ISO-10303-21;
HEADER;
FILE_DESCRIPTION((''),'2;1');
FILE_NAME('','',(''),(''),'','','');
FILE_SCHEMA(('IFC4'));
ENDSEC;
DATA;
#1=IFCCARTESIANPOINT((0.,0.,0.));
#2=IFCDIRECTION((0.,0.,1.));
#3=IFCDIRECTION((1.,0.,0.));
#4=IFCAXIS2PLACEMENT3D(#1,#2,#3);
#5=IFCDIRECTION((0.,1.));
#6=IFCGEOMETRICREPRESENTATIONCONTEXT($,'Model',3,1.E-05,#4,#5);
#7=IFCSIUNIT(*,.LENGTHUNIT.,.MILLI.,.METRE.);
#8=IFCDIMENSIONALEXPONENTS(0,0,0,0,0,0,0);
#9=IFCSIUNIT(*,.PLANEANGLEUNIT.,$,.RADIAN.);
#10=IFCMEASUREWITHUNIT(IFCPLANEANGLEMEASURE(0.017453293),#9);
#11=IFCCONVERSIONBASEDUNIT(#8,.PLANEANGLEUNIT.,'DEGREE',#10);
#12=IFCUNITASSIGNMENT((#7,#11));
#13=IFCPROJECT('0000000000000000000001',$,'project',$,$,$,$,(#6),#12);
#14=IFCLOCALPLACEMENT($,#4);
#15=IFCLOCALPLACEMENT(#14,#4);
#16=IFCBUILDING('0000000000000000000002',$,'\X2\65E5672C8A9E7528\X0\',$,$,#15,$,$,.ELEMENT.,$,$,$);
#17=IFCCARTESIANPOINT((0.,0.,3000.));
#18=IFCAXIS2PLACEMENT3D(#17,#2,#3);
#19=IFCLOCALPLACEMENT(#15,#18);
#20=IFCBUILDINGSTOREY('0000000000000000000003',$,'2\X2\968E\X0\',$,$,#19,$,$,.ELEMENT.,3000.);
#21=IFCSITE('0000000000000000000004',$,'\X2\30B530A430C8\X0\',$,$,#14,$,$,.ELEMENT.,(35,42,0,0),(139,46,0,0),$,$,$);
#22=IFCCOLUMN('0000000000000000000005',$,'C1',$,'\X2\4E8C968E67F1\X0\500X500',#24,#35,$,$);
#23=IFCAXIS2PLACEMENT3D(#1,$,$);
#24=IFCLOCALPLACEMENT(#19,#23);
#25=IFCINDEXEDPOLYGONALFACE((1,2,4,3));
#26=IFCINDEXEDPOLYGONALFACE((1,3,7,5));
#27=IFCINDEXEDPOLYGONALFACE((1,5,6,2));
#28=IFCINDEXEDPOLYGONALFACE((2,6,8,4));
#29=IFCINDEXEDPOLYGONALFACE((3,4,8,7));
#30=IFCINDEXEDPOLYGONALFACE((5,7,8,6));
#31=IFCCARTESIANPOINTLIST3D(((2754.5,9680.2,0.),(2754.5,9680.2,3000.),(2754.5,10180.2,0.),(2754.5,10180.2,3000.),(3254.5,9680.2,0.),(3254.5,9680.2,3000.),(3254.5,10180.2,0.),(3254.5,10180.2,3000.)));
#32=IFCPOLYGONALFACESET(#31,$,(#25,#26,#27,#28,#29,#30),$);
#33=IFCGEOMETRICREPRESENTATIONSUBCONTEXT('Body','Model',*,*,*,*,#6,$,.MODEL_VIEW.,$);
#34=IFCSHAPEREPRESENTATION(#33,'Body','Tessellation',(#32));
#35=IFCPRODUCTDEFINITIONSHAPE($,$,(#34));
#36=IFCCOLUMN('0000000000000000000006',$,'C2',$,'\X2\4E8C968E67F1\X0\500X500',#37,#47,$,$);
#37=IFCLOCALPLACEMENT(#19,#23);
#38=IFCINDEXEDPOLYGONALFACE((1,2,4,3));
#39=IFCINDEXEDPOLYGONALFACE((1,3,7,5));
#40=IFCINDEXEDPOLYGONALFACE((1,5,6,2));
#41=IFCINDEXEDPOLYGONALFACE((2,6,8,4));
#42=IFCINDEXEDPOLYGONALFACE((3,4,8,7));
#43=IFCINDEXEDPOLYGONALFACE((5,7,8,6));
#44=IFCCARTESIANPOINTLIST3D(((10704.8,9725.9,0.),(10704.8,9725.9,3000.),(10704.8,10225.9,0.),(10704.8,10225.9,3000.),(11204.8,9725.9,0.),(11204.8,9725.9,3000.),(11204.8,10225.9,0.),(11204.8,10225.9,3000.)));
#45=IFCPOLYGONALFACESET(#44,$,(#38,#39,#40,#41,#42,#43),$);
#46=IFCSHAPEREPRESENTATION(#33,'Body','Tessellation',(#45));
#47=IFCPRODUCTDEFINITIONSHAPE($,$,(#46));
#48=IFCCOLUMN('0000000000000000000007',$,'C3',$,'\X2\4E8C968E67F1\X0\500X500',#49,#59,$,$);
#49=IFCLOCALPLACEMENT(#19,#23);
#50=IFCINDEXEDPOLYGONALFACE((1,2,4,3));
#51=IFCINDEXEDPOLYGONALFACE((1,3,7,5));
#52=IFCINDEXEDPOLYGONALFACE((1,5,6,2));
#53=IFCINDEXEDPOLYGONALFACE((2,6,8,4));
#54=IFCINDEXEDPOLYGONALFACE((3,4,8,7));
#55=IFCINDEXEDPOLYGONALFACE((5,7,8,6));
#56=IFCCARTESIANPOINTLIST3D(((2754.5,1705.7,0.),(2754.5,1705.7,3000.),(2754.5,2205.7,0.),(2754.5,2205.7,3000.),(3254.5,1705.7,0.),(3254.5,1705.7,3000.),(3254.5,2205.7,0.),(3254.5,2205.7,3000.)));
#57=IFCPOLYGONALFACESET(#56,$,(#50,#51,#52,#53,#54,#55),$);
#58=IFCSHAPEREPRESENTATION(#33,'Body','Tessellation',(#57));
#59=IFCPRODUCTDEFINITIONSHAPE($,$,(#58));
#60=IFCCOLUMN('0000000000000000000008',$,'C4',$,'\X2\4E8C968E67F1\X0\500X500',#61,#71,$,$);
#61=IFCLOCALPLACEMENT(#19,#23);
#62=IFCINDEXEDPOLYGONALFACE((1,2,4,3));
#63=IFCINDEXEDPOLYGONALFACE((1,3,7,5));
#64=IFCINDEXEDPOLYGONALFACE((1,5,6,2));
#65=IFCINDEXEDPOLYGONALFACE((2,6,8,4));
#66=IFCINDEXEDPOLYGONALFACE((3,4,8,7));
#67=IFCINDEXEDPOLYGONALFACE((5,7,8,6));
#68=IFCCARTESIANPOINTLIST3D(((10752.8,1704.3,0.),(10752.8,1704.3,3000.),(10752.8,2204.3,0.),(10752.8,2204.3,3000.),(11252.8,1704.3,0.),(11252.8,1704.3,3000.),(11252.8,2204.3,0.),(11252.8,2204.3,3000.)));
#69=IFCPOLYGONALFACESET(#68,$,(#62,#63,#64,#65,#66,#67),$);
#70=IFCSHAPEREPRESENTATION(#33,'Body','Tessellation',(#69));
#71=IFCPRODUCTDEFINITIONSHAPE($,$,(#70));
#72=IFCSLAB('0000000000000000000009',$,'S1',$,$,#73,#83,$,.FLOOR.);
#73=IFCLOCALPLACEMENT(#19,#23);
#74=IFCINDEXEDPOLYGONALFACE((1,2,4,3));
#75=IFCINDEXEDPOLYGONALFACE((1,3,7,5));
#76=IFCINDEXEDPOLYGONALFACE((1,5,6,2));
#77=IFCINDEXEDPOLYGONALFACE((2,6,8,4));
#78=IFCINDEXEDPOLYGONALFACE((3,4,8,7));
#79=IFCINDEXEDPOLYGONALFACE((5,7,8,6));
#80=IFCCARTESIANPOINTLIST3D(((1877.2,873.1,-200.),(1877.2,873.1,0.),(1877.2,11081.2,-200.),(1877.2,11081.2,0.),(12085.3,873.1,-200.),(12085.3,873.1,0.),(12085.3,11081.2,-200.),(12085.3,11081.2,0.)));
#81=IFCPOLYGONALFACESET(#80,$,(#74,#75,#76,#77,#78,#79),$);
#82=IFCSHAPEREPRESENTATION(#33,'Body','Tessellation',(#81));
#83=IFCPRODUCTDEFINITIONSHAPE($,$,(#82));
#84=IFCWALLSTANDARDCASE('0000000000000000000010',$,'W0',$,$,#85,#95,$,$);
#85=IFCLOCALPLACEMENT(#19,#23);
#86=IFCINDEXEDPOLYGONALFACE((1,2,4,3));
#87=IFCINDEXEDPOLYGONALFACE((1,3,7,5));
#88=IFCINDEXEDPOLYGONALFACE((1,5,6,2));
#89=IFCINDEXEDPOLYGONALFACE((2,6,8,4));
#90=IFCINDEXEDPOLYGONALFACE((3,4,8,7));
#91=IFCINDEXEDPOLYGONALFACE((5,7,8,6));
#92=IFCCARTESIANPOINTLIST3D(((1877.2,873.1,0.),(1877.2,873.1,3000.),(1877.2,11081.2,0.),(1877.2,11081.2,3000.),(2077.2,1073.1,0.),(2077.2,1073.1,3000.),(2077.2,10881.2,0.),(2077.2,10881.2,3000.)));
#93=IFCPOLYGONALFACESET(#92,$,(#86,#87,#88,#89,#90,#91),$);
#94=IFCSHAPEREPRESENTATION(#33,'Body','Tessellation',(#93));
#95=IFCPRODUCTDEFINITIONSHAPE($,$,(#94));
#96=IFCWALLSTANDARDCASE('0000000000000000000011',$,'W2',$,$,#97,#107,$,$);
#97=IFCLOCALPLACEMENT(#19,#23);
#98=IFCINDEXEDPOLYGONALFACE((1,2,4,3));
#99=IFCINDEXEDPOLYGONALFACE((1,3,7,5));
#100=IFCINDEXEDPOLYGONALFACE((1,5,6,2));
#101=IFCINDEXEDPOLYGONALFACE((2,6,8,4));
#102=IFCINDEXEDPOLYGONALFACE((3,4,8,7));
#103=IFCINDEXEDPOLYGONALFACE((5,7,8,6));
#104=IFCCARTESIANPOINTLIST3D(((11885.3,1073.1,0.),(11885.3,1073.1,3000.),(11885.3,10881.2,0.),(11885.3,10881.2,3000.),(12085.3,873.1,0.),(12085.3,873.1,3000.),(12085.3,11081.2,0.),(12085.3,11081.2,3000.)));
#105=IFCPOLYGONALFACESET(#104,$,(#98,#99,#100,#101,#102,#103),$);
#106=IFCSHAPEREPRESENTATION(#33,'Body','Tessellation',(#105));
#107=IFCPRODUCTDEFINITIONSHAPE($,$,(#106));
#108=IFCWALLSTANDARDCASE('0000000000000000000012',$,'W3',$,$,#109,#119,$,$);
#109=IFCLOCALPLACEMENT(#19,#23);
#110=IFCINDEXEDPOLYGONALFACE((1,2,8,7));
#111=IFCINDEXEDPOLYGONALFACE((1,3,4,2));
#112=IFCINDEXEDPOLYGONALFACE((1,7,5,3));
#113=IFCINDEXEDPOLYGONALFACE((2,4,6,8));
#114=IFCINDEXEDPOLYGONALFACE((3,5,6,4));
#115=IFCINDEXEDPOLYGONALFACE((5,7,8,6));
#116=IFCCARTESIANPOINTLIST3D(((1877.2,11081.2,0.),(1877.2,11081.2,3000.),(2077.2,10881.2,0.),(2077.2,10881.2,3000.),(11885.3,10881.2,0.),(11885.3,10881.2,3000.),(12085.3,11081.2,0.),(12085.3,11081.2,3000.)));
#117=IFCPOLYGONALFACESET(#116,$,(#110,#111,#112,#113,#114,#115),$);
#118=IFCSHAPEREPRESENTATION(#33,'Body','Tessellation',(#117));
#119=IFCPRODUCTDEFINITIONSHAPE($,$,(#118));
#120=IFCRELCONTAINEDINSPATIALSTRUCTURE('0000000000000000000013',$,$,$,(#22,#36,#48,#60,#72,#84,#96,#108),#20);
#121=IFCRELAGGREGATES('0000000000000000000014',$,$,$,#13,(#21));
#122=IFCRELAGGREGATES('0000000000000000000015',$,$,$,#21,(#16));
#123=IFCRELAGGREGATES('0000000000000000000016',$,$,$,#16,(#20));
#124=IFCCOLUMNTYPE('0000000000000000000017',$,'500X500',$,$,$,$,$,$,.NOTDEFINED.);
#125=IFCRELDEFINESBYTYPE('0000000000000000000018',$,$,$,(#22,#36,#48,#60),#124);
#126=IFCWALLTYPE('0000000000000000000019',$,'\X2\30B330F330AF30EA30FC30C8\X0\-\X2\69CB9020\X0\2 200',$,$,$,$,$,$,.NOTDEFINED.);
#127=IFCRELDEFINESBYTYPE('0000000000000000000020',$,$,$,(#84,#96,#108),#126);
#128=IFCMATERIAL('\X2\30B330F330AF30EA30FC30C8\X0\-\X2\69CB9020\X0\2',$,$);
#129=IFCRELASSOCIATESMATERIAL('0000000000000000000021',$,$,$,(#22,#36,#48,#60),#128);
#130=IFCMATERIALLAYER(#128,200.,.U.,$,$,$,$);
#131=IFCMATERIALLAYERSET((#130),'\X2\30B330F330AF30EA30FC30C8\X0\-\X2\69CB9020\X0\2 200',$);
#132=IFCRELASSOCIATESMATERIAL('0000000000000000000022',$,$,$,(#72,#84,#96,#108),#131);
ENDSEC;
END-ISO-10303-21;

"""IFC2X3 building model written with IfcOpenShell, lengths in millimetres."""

from ifc_helpers import new_model, entity, si_unit, converted_unit, direction, frame, origin_with_axes, origin_2d_with_axis, place, context, subcontext, project, spatial, polyline, rectangle, outline, extrude, material, layer, layer_set, layer_usage, type_object, element, save


model = new_model("IFC2X3")

# Units and contexts
model_context = context("Model", 3, precision=1e-05, world=origin_with_axes(), true_north=direction((0.0, 1.0)))
body_context = subcontext(model_context, "Body", "Model", "MODEL_VIEW")
ifc_project = project(units=[si_unit("LENGTHUNIT", "METRE", prefix="MILLI"), converted_unit("PLANEANGLEUNIT", "DEGREE", entity("IfcPlaneAngleMeasure", 0.017453293), si_unit("PLANEANGLEUNIT", "RADIAN"), dimensions=[0, 0, 0, 0, 0, 0, 0])], contexts=[model_context])

# Site, building, storey
site_placement = place(None, origin_with_axes())
site = spatial("IfcSite", under=ifc_project, at=site_placement, Name="サイト", CompositionType="ELEMENT", RefLatitude=(35, 42, 0, 0), RefLongitude=(139, 46, 0, 0))
building_placement = place(site_placement, origin_with_axes())
building = spatial("IfcBuilding", under=site, at=building_placement, Name="日本語用", CompositionType="ELEMENT")
storey_placement = place(building_placement, frame((0.0, 0.0, 3000.0), z_axis=(0.0, 0.0, 1.0), x_axis=(1.0, 0.0, 0.0)))
storey = spatial("IfcBuildingStorey", under=building, at=storey_placement, Name="2階", CompositionType="ELEMENT", Elevation=3000.0)

# Columns
ifc_material = material(Name="コンクリート-構造2")
column_type = type_object("IfcColumnType", Name="500X500", PredefinedType="NOTDEFINED")
for number, where, z_axis, x_axis, name in (
    (1, (3004.5, 9930.2, 0.0), (0.0, 0.0, 1.0), (1.0, 0.0, 0.0), "C1"),
    (2, (10954.8, 9975.9, 0.0), (0.0, 0.0, 1.0), (1.0, 0.0, 0.0), "C2"),
    (3, (3004.5, 1955.7, 0.0), (0.0, 0.0, 1.0), (1.0, 0.0, 0.0), "C3"),
    (4, (11002.8, 1954.3, 0.0), (0.0, 0.0, 1.0), (1.0, 0.0, 0.0), "C4"),
):
    element("IfcColumn", number, at=place(storey_placement, frame(where, z_axis=z_axis, x_axis=x_axis)), inside=storey, type_object=column_type, material=ifc_material, Name=name, ObjectType="二階柱500X500", context=body_context, shape_type="SweptSolid", body=[
        extrude(rectangle(XDim=500.0, YDim=500.0, at=origin_2d_with_axis()), origin_with_axes(), (0.0, 0.0, 1.0), 3000.0),
    ])

# Slab
ifc_layer = layer(ifc_material, 200.0, ventilated="UNKNOWN")
ifc_layer_set = layer_set([ifc_layer], Name="コンクリート-構造2 200")
ifc_layer_usage_1 = layer_usage(ifc_layer_set, "AXIS3", "NEGATIVE", 200.0)
slab_1_placement = place(storey_placement, frame((1877.2, 11081.2, -200.0), z_axis=(0.0, 0.0, 1.0), x_axis=(1.0, 0.0, 0.0)))
element("IfcSlab", 5, at=slab_1_placement, inside=storey, material=ifc_layer_usage_1, Name="S1", PredefinedType="FLOOR", context=body_context, shape_type="SweptSolid", body=[
    extrude(outline(polyline([(0.0, 0.0), (0.0, -10208.1), (10208.1, -10208.1), (10208.1, 0.0), (0.0, 0.0)])), origin_with_axes(), (0.0, 0.0, 1.0), 200.0),
])

# Wall
ifc_layer_usage_2 = layer_usage(ifc_layer_set, "AXIS2", "NEGATIVE", 100.0)
wall_type = type_object("IfcWallType", Name="コンクリート-構造2 200", PredefinedType="NOTDEFINED")
wall_1_placement = place(storey_placement, frame((1977.2, 10981.2, 0.0), z_axis=(0.0, 0.0, 1.0), x_axis=(0.0, -1.0, 0.0)))
element("IfcWallStandardCase", 6, at=wall_1_placement, inside=storey, type_object=wall_type, material=ifc_layer_usage_2, Name="W0", context=body_context, shape_type="SweptSolid", body=[
    extrude(outline(polyline([(-100.0, -100.0), (10108.1, -100.0), (9908.1, 100.0), (100.0, 100.0), (-100.0, -100.0)])), origin_with_axes(), (0.0, 0.0, 1.0), 3000.0),
])

# Walls
ifc_layer_usage_3 = layer_usage(ifc_layer_set, "AXIS2", "NEGATIVE", 100.0)
wall_2_placement = place(storey_placement, frame((11985.3, 973.1, 0.0), z_axis=(0.0, 0.0, 1.0), x_axis=(0.0, 1.0, 0.0)))
element("IfcWallStandardCase", 7, at=wall_2_placement, inside=storey, type_object=wall_type, material=ifc_layer_usage_3, Name="W2", context=body_context, shape_type="SweptSolid", body=[
    extrude(outline(polyline([(-100.0, -100.0), (10108.1, -100.0), (9908.1, 100.0), (100.0, 100.0), (-100.0, -100.0)])), origin_with_axes(), (0.0, 0.0, 1.0), 3000.0),
])
ifc_layer_usage_4 = layer_usage(ifc_layer_set, "AXIS2", "NEGATIVE", 100.0)
wall_3_placement = place(storey_placement, frame((11985.3, 10981.2, 0.0), z_axis=(0.0, 0.0, 1.0), x_axis=(-1.0, 0.0, 0.0)))
element("IfcWallStandardCase", 8, at=wall_3_placement, inside=storey, type_object=wall_type, material=ifc_layer_usage_4, Name="W3", context=body_context, shape_type="SweptSolid", body=[
    extrude(outline(polyline([(-100.0, -100.0), (10108.1, -100.0), (9908.1, 100.0), (100.0, 100.0), (-100.0, -100.0)])), origin_with_axes(), (0.0, 0.0, 1.0), 3000.0),
])

save(model, "model.ifc")
